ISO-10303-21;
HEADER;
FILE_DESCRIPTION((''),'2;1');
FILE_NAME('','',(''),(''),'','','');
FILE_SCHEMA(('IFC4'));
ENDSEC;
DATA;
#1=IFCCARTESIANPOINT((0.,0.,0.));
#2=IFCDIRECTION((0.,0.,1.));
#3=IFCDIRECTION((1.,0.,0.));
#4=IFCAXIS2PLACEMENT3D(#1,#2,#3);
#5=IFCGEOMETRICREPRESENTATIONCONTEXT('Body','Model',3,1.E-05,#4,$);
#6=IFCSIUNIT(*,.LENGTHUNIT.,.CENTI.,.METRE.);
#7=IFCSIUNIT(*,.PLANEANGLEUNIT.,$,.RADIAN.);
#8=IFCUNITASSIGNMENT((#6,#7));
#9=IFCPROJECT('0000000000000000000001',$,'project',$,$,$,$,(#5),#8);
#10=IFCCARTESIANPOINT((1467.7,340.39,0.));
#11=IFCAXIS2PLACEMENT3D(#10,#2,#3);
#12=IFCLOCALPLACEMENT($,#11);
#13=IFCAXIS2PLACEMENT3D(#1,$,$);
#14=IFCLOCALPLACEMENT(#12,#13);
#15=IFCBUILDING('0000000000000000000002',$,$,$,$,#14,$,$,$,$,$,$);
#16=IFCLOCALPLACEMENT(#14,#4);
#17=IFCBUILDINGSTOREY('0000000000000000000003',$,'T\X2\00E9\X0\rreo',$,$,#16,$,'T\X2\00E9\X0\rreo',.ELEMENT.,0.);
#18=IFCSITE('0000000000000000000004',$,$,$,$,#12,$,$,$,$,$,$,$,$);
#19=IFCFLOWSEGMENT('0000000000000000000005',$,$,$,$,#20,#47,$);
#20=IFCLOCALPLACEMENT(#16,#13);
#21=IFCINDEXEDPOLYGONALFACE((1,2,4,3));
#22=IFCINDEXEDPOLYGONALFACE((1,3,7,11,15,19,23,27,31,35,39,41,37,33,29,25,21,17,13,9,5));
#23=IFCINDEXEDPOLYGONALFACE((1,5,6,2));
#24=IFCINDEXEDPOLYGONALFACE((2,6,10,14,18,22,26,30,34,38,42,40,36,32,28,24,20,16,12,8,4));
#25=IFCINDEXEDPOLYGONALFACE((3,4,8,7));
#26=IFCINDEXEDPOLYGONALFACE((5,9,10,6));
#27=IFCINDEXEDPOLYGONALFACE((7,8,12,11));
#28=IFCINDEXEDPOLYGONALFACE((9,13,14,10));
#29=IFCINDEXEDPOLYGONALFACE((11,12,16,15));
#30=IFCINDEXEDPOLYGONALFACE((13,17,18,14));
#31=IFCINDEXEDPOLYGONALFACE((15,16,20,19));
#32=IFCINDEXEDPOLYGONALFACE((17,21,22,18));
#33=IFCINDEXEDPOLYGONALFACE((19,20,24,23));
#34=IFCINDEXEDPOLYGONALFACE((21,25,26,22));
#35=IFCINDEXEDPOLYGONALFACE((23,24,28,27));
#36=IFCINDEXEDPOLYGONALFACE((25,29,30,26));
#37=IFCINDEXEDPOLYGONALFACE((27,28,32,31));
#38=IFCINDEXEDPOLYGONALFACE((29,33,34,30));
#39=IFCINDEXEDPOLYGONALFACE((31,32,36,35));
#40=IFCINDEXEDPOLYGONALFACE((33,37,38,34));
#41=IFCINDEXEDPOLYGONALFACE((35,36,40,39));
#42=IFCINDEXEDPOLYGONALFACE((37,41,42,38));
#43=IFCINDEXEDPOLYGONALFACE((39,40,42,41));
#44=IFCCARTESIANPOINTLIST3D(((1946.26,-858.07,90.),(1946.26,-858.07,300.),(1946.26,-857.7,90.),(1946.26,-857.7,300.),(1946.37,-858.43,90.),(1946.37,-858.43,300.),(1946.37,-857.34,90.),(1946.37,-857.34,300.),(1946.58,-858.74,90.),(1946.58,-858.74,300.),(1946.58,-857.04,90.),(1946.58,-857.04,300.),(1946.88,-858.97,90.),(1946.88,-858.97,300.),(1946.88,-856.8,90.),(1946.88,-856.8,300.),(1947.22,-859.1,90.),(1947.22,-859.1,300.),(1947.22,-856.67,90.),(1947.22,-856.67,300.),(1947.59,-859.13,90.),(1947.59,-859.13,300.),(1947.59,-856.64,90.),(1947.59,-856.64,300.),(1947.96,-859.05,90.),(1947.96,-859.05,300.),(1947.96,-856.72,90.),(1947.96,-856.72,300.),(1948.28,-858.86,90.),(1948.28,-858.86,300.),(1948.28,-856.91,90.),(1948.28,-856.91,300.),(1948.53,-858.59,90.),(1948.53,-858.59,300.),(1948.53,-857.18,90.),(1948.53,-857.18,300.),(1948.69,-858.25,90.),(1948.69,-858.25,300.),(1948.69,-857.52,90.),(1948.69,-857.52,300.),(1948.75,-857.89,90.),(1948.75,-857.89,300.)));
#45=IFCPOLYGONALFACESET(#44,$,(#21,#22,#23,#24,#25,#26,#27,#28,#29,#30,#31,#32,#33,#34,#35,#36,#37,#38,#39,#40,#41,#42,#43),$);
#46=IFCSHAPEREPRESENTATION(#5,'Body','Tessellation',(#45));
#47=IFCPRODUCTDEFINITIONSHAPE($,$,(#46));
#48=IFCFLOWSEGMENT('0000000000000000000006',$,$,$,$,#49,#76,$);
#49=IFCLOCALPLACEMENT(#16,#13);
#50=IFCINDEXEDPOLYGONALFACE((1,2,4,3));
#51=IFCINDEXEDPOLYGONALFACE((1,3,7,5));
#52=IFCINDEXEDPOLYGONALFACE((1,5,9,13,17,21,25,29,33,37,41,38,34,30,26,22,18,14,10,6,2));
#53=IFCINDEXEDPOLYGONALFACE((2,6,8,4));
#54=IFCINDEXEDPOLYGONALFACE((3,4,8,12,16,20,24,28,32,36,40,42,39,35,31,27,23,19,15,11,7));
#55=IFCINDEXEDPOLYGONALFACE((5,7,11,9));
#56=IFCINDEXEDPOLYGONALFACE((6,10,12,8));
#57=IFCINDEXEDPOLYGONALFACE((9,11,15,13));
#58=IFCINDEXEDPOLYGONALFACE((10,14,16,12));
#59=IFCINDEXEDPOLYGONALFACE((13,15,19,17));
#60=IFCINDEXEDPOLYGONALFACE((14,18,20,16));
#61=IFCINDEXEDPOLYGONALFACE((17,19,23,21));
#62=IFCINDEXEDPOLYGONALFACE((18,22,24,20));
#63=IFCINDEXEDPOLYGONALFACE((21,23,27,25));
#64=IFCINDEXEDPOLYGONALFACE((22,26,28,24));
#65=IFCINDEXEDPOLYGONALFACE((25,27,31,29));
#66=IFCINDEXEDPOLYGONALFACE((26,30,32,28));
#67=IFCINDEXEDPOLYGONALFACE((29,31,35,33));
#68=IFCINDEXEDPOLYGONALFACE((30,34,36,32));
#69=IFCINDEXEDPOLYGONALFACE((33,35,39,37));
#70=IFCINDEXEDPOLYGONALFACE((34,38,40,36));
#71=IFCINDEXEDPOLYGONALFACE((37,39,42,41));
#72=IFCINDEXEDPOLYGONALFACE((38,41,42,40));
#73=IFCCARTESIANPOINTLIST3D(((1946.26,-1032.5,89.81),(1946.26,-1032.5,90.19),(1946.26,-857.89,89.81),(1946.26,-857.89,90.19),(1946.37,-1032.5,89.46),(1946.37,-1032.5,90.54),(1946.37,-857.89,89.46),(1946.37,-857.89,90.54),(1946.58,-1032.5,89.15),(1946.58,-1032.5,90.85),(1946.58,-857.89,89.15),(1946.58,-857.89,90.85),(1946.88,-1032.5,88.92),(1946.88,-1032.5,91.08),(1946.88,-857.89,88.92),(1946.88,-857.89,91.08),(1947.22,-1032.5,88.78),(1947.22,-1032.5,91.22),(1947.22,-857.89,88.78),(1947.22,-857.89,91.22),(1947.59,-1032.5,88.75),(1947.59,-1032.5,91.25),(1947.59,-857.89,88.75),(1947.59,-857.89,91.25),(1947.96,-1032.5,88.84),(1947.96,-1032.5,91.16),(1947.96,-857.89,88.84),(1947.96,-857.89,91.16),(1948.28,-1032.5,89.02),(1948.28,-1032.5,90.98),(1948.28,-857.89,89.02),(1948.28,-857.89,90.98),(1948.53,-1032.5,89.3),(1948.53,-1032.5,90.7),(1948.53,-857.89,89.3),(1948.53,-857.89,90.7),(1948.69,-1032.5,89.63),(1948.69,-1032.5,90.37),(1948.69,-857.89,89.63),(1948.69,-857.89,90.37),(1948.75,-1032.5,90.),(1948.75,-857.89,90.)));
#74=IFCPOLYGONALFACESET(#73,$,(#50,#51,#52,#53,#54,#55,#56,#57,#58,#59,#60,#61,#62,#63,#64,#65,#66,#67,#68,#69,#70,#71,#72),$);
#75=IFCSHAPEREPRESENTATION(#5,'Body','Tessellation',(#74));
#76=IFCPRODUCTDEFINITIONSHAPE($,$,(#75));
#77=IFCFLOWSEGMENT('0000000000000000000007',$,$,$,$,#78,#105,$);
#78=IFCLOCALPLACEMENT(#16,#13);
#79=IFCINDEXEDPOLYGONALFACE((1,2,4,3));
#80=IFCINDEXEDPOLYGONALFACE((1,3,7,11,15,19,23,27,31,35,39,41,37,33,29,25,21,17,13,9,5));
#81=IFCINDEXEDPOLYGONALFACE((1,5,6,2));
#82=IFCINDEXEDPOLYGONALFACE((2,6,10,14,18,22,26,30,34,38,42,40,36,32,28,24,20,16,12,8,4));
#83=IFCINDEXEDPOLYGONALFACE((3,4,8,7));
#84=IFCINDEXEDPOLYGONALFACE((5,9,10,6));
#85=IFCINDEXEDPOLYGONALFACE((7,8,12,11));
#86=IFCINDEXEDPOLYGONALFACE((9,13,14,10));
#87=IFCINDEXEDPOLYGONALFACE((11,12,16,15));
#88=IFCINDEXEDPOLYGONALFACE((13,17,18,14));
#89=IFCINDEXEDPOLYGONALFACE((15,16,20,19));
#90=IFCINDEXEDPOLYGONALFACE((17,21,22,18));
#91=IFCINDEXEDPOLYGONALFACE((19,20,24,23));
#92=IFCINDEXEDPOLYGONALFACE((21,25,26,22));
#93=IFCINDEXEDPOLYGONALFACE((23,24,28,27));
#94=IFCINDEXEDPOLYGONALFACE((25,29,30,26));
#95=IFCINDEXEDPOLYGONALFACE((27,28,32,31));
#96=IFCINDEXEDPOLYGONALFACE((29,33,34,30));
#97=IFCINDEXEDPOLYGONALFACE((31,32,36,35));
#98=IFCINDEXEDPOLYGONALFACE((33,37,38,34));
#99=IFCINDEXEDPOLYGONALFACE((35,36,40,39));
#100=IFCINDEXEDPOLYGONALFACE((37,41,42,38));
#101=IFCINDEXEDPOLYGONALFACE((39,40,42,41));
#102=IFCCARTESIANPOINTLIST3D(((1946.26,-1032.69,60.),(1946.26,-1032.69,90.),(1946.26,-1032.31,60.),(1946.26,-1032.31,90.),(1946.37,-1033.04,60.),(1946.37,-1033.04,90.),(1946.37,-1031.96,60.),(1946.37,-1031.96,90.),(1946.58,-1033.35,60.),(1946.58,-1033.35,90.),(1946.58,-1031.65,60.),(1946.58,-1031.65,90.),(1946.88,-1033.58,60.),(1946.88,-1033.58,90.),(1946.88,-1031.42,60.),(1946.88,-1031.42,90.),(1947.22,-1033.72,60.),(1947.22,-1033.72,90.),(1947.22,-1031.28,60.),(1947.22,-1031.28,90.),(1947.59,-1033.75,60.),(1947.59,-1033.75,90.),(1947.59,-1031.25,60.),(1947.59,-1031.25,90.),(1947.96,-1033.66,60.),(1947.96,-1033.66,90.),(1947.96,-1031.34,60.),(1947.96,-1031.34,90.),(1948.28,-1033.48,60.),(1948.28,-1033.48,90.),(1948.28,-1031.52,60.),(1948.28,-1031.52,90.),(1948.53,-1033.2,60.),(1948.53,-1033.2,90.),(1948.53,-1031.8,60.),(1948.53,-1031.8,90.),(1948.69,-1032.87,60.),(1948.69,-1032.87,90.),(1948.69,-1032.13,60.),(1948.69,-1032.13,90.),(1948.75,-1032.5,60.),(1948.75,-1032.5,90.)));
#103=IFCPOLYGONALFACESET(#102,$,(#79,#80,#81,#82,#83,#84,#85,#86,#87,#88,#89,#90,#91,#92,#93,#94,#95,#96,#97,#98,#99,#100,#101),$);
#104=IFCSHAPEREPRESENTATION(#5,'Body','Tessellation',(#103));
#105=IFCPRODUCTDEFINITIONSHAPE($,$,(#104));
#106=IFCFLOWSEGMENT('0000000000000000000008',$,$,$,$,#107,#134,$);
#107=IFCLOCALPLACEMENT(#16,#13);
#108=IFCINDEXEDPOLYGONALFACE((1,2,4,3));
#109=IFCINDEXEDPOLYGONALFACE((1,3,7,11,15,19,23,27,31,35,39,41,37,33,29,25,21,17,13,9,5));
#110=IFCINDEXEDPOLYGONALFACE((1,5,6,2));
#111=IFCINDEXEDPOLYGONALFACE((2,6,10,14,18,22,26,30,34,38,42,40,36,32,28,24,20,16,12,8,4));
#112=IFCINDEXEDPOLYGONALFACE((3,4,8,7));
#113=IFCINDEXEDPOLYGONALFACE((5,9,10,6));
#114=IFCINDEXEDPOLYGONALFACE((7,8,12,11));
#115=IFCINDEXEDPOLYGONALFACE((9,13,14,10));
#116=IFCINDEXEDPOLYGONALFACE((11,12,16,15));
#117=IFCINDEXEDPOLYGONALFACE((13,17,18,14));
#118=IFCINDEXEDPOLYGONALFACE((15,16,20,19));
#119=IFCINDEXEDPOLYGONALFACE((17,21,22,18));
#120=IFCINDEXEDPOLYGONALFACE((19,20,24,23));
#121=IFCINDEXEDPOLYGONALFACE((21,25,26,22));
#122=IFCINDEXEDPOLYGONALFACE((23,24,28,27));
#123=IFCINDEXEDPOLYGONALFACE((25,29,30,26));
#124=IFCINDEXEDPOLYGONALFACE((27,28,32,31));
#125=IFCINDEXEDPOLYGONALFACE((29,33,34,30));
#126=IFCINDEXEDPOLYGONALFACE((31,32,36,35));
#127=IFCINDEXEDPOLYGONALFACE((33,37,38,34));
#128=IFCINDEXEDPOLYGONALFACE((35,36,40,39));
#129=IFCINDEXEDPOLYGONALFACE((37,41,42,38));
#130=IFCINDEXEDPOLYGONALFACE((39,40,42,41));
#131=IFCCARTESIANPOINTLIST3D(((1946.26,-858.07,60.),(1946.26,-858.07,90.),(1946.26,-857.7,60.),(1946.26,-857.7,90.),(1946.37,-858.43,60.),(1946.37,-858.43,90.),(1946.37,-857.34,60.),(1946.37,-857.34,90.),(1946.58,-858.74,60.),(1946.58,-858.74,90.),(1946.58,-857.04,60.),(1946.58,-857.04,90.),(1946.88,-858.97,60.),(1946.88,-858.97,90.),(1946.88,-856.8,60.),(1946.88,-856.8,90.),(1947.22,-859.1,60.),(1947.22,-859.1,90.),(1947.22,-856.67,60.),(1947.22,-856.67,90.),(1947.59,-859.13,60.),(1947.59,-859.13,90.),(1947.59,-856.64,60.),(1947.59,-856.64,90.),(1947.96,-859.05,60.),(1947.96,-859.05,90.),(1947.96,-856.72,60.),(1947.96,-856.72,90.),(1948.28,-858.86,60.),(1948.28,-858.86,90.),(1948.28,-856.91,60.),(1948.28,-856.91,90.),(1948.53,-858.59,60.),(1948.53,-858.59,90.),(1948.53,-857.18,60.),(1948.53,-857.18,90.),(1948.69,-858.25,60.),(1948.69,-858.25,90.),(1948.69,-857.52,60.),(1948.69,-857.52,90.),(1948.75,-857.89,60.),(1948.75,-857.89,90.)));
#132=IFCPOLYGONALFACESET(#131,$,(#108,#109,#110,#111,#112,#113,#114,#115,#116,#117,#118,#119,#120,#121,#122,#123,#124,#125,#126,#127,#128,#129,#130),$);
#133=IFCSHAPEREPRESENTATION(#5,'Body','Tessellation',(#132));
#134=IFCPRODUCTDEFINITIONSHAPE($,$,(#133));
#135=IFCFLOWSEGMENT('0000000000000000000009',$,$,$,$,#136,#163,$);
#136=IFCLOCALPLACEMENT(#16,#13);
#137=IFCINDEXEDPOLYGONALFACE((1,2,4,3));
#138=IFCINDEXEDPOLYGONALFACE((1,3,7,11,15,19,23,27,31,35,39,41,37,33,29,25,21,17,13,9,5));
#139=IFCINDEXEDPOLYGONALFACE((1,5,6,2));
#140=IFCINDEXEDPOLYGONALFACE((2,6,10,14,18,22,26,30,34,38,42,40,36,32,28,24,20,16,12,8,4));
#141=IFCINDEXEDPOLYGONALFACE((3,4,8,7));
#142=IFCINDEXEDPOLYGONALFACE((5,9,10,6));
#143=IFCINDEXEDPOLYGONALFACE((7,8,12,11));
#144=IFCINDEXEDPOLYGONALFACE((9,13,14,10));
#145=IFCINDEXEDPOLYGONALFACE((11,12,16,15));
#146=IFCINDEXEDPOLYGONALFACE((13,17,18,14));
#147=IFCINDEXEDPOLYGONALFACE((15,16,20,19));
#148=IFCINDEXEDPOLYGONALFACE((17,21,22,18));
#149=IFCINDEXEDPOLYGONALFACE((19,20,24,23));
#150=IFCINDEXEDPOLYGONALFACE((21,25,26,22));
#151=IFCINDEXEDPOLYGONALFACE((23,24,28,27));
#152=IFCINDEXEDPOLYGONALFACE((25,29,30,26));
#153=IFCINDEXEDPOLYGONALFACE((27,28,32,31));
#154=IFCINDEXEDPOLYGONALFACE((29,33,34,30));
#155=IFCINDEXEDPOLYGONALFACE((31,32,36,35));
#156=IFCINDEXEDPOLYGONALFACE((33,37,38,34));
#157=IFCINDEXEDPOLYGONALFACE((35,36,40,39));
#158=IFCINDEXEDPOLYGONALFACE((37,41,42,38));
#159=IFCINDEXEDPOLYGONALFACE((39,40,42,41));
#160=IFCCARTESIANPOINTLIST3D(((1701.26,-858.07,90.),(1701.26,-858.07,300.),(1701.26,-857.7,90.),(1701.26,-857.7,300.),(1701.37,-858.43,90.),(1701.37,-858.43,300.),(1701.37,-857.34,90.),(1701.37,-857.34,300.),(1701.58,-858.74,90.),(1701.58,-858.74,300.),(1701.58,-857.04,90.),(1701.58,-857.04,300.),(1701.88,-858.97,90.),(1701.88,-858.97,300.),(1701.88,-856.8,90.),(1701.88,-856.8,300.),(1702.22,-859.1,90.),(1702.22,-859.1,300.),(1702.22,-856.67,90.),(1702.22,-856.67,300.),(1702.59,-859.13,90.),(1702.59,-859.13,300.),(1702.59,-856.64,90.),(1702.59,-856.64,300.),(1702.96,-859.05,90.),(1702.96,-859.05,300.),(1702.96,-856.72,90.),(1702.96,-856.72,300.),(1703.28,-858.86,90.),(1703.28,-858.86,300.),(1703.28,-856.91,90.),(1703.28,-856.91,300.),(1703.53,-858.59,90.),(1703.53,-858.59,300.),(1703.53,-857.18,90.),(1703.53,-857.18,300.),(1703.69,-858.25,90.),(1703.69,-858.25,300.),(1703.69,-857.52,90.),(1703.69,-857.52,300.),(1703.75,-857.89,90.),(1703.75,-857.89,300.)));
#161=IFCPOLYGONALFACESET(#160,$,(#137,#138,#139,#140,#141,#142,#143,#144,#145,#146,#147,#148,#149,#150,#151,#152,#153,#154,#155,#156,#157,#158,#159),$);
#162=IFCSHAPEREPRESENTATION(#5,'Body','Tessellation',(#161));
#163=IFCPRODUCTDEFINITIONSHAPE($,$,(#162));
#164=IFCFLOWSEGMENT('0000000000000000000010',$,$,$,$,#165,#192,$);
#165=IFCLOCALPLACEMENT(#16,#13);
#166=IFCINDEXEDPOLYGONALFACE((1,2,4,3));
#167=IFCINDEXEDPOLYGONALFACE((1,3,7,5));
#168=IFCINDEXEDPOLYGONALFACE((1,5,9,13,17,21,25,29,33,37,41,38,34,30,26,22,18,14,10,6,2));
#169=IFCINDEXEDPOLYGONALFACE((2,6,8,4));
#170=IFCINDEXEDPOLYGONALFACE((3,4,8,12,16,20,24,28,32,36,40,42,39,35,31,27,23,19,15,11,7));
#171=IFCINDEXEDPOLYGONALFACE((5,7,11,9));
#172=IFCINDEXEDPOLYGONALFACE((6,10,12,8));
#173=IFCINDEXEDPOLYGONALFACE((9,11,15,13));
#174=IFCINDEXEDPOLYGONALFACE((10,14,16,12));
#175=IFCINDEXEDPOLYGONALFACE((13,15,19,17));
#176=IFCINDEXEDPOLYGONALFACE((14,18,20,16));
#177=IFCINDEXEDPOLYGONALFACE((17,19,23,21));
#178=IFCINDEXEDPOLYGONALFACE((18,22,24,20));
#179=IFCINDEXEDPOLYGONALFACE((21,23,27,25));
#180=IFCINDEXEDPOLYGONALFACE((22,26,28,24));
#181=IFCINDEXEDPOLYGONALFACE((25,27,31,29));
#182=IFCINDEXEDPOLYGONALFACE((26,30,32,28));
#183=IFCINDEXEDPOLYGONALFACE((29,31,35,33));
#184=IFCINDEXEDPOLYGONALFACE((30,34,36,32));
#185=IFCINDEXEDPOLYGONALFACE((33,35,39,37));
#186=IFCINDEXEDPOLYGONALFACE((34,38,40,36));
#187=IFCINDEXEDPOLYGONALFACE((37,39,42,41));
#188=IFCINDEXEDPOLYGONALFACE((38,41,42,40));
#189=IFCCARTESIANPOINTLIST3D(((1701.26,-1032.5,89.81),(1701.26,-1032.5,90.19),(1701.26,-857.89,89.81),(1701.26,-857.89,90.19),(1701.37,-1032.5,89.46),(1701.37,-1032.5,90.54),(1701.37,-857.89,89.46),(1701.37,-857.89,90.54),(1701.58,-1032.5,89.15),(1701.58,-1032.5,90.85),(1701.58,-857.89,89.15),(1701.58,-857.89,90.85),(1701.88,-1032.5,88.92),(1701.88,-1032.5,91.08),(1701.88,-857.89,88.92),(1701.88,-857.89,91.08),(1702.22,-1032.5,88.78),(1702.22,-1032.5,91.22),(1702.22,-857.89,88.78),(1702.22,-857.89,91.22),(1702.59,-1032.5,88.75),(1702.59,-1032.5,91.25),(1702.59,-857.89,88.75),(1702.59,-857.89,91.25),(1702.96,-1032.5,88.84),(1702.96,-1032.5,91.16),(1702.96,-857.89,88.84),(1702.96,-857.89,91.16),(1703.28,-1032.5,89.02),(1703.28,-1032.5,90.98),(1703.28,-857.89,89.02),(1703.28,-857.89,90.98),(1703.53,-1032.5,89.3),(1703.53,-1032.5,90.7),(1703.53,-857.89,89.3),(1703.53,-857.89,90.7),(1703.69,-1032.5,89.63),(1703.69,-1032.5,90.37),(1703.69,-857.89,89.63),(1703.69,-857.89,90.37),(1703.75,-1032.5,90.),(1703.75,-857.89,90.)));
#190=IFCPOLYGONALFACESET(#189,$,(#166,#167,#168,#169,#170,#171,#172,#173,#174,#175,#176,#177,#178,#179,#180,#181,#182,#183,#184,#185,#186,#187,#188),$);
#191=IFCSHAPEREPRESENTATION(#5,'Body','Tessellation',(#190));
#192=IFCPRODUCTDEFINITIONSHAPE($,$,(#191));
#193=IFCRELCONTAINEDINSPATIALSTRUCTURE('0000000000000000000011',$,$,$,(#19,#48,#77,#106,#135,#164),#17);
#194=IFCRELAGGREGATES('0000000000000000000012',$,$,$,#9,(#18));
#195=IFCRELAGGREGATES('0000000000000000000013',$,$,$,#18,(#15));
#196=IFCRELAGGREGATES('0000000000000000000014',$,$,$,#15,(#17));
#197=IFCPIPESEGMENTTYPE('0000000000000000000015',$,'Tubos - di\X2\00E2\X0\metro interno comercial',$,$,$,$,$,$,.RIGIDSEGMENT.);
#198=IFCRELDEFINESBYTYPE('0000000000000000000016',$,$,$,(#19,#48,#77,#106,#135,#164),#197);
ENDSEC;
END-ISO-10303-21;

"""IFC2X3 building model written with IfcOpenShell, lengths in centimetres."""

from ifc_helpers import new_model, si_unit, frame, origin, origin_with_axes, origin_2d_with_axis, place, context, project, spatial, circle, extrude, type_object, element, save


model = new_model("IFC2X3")

# Units and contexts
model_context = context("Model", 3, precision=1e-05, world=origin_with_axes(), identifier="Body")
ifc_project = project(units=[si_unit("LENGTHUNIT", "METRE", prefix="CENTI"), si_unit("PLANEANGLEUNIT", "RADIAN")], contexts=[model_context])

# Site, building, storey
site_placement = place(None, frame((1467.7, 340.39, 0.0), z_axis=(0.0, 0.0, 1.0), x_axis=(1.0, 0.0, 0.0)))
site = spatial("IfcSite", under=ifc_project, at=site_placement)
building_placement = place(site_placement, origin())
building = spatial("IfcBuilding", under=site, at=building_placement)
storey_placement = place(building_placement, origin_with_axes())
storey = spatial("IfcBuildingStorey", under=building, at=storey_placement, Name="Térreo", LongName="Térreo", CompositionType="ELEMENT", Elevation=0.0)

# Flow segments
pipe_segment_type = type_object("IfcPipeSegmentType", Name="Tubos - diâmetro interno comercial", PredefinedType="RIGIDSEGMENT")
flow_segment_1_placement = place(storey_placement, frame((1947.5, -857.89, 300.0), z_axis=(0.0, 0.0, 1.0), x_axis=(1.0, 0.0, 0.0)))
element("IfcFlowSegment", 1, at=flow_segment_1_placement, inside=storey, type_object=pipe_segment_type, context=model_context, shape_type="SolidModel", body=[
    extrude(circle(Radius=1.25, at=origin_2d_with_axis()), frame((0.0, 0.0, 0.0), z_axis=(0.0, 0.0, -1.0), x_axis=(1.0, 0.0, 0.0)), (0.0, 0.0, 1.0), 210.0),
])
flow_segment_2_placement = place(storey_placement, frame((1947.5, -945.19, 91.25), z_axis=(0.0, 0.0, 1.0), x_axis=(1.0, 0.0, 0.0)))
element("IfcFlowSegment", 2, at=flow_segment_2_placement, inside=storey, type_object=pipe_segment_type, context=model_context, shape_type="SolidModel", body=[
    extrude(circle(Radius=1.25, at=origin_2d_with_axis()), frame((0.0, 87.31, -1.25), z_axis=(0.0, -1.0, 0.0), x_axis=(1.0, 0.0, 0.0)), (0.0, 0.0, 1.0), 174.61),
])
for number, where, z_axis, x_axis in (
    (3, (1947.5, -1032.5, 90.0), (0.0, 0.0, 1.0), (1.0, 0.0, 0.0)),
    (4, (1947.5, -857.89, 90.0), (0.0, 0.0, 1.0), (1.0, 0.0, 0.0)),
):
    element("IfcFlowSegment", number, at=place(storey_placement, frame(where, z_axis=z_axis, x_axis=x_axis)), inside=storey, type_object=pipe_segment_type, context=model_context, shape_type="SolidModel", body=[
        extrude(circle(Radius=1.25, at=origin_2d_with_axis()), frame((0.0, 0.0, 0.0), z_axis=(0.0, 0.0, -1.0), x_axis=(1.0, 0.0, 0.0)), (0.0, 0.0, 1.0), 30.0),
    ])
flow_segment_3_placement = place(storey_placement, frame((1702.5, -857.89, 300.0), z_axis=(0.0, 0.0, 1.0), x_axis=(1.0, 0.0, 0.0)))
element("IfcFlowSegment", 5, at=flow_segment_3_placement, inside=storey, type_object=pipe_segment_type, context=model_context, shape_type="SolidModel", body=[
    extrude(circle(Radius=1.25, at=origin_2d_with_axis()), frame((0.0, 0.0, 0.0), z_axis=(0.0, 0.0, -1.0), x_axis=(1.0, 0.0, 0.0)), (0.0, 0.0, 1.0), 210.0),
])
flow_segment_4_placement = place(storey_placement, frame((1702.5, -945.19, 91.25), z_axis=(0.0, 0.0, 1.0), x_axis=(1.0, 0.0, 0.0)))
element("IfcFlowSegment", 6, at=flow_segment_4_placement, inside=storey, type_object=pipe_segment_type, context=model_context, shape_type="SolidModel", body=[
    extrude(circle(Radius=1.25, at=origin_2d_with_axis()), frame((0.0, 87.31, -1.25), z_axis=(0.0, -1.0, 0.0), x_axis=(1.0, 0.0, 0.0)), (0.0, 0.0, 1.0), 174.61),
])

save(model, "model.ifc")
